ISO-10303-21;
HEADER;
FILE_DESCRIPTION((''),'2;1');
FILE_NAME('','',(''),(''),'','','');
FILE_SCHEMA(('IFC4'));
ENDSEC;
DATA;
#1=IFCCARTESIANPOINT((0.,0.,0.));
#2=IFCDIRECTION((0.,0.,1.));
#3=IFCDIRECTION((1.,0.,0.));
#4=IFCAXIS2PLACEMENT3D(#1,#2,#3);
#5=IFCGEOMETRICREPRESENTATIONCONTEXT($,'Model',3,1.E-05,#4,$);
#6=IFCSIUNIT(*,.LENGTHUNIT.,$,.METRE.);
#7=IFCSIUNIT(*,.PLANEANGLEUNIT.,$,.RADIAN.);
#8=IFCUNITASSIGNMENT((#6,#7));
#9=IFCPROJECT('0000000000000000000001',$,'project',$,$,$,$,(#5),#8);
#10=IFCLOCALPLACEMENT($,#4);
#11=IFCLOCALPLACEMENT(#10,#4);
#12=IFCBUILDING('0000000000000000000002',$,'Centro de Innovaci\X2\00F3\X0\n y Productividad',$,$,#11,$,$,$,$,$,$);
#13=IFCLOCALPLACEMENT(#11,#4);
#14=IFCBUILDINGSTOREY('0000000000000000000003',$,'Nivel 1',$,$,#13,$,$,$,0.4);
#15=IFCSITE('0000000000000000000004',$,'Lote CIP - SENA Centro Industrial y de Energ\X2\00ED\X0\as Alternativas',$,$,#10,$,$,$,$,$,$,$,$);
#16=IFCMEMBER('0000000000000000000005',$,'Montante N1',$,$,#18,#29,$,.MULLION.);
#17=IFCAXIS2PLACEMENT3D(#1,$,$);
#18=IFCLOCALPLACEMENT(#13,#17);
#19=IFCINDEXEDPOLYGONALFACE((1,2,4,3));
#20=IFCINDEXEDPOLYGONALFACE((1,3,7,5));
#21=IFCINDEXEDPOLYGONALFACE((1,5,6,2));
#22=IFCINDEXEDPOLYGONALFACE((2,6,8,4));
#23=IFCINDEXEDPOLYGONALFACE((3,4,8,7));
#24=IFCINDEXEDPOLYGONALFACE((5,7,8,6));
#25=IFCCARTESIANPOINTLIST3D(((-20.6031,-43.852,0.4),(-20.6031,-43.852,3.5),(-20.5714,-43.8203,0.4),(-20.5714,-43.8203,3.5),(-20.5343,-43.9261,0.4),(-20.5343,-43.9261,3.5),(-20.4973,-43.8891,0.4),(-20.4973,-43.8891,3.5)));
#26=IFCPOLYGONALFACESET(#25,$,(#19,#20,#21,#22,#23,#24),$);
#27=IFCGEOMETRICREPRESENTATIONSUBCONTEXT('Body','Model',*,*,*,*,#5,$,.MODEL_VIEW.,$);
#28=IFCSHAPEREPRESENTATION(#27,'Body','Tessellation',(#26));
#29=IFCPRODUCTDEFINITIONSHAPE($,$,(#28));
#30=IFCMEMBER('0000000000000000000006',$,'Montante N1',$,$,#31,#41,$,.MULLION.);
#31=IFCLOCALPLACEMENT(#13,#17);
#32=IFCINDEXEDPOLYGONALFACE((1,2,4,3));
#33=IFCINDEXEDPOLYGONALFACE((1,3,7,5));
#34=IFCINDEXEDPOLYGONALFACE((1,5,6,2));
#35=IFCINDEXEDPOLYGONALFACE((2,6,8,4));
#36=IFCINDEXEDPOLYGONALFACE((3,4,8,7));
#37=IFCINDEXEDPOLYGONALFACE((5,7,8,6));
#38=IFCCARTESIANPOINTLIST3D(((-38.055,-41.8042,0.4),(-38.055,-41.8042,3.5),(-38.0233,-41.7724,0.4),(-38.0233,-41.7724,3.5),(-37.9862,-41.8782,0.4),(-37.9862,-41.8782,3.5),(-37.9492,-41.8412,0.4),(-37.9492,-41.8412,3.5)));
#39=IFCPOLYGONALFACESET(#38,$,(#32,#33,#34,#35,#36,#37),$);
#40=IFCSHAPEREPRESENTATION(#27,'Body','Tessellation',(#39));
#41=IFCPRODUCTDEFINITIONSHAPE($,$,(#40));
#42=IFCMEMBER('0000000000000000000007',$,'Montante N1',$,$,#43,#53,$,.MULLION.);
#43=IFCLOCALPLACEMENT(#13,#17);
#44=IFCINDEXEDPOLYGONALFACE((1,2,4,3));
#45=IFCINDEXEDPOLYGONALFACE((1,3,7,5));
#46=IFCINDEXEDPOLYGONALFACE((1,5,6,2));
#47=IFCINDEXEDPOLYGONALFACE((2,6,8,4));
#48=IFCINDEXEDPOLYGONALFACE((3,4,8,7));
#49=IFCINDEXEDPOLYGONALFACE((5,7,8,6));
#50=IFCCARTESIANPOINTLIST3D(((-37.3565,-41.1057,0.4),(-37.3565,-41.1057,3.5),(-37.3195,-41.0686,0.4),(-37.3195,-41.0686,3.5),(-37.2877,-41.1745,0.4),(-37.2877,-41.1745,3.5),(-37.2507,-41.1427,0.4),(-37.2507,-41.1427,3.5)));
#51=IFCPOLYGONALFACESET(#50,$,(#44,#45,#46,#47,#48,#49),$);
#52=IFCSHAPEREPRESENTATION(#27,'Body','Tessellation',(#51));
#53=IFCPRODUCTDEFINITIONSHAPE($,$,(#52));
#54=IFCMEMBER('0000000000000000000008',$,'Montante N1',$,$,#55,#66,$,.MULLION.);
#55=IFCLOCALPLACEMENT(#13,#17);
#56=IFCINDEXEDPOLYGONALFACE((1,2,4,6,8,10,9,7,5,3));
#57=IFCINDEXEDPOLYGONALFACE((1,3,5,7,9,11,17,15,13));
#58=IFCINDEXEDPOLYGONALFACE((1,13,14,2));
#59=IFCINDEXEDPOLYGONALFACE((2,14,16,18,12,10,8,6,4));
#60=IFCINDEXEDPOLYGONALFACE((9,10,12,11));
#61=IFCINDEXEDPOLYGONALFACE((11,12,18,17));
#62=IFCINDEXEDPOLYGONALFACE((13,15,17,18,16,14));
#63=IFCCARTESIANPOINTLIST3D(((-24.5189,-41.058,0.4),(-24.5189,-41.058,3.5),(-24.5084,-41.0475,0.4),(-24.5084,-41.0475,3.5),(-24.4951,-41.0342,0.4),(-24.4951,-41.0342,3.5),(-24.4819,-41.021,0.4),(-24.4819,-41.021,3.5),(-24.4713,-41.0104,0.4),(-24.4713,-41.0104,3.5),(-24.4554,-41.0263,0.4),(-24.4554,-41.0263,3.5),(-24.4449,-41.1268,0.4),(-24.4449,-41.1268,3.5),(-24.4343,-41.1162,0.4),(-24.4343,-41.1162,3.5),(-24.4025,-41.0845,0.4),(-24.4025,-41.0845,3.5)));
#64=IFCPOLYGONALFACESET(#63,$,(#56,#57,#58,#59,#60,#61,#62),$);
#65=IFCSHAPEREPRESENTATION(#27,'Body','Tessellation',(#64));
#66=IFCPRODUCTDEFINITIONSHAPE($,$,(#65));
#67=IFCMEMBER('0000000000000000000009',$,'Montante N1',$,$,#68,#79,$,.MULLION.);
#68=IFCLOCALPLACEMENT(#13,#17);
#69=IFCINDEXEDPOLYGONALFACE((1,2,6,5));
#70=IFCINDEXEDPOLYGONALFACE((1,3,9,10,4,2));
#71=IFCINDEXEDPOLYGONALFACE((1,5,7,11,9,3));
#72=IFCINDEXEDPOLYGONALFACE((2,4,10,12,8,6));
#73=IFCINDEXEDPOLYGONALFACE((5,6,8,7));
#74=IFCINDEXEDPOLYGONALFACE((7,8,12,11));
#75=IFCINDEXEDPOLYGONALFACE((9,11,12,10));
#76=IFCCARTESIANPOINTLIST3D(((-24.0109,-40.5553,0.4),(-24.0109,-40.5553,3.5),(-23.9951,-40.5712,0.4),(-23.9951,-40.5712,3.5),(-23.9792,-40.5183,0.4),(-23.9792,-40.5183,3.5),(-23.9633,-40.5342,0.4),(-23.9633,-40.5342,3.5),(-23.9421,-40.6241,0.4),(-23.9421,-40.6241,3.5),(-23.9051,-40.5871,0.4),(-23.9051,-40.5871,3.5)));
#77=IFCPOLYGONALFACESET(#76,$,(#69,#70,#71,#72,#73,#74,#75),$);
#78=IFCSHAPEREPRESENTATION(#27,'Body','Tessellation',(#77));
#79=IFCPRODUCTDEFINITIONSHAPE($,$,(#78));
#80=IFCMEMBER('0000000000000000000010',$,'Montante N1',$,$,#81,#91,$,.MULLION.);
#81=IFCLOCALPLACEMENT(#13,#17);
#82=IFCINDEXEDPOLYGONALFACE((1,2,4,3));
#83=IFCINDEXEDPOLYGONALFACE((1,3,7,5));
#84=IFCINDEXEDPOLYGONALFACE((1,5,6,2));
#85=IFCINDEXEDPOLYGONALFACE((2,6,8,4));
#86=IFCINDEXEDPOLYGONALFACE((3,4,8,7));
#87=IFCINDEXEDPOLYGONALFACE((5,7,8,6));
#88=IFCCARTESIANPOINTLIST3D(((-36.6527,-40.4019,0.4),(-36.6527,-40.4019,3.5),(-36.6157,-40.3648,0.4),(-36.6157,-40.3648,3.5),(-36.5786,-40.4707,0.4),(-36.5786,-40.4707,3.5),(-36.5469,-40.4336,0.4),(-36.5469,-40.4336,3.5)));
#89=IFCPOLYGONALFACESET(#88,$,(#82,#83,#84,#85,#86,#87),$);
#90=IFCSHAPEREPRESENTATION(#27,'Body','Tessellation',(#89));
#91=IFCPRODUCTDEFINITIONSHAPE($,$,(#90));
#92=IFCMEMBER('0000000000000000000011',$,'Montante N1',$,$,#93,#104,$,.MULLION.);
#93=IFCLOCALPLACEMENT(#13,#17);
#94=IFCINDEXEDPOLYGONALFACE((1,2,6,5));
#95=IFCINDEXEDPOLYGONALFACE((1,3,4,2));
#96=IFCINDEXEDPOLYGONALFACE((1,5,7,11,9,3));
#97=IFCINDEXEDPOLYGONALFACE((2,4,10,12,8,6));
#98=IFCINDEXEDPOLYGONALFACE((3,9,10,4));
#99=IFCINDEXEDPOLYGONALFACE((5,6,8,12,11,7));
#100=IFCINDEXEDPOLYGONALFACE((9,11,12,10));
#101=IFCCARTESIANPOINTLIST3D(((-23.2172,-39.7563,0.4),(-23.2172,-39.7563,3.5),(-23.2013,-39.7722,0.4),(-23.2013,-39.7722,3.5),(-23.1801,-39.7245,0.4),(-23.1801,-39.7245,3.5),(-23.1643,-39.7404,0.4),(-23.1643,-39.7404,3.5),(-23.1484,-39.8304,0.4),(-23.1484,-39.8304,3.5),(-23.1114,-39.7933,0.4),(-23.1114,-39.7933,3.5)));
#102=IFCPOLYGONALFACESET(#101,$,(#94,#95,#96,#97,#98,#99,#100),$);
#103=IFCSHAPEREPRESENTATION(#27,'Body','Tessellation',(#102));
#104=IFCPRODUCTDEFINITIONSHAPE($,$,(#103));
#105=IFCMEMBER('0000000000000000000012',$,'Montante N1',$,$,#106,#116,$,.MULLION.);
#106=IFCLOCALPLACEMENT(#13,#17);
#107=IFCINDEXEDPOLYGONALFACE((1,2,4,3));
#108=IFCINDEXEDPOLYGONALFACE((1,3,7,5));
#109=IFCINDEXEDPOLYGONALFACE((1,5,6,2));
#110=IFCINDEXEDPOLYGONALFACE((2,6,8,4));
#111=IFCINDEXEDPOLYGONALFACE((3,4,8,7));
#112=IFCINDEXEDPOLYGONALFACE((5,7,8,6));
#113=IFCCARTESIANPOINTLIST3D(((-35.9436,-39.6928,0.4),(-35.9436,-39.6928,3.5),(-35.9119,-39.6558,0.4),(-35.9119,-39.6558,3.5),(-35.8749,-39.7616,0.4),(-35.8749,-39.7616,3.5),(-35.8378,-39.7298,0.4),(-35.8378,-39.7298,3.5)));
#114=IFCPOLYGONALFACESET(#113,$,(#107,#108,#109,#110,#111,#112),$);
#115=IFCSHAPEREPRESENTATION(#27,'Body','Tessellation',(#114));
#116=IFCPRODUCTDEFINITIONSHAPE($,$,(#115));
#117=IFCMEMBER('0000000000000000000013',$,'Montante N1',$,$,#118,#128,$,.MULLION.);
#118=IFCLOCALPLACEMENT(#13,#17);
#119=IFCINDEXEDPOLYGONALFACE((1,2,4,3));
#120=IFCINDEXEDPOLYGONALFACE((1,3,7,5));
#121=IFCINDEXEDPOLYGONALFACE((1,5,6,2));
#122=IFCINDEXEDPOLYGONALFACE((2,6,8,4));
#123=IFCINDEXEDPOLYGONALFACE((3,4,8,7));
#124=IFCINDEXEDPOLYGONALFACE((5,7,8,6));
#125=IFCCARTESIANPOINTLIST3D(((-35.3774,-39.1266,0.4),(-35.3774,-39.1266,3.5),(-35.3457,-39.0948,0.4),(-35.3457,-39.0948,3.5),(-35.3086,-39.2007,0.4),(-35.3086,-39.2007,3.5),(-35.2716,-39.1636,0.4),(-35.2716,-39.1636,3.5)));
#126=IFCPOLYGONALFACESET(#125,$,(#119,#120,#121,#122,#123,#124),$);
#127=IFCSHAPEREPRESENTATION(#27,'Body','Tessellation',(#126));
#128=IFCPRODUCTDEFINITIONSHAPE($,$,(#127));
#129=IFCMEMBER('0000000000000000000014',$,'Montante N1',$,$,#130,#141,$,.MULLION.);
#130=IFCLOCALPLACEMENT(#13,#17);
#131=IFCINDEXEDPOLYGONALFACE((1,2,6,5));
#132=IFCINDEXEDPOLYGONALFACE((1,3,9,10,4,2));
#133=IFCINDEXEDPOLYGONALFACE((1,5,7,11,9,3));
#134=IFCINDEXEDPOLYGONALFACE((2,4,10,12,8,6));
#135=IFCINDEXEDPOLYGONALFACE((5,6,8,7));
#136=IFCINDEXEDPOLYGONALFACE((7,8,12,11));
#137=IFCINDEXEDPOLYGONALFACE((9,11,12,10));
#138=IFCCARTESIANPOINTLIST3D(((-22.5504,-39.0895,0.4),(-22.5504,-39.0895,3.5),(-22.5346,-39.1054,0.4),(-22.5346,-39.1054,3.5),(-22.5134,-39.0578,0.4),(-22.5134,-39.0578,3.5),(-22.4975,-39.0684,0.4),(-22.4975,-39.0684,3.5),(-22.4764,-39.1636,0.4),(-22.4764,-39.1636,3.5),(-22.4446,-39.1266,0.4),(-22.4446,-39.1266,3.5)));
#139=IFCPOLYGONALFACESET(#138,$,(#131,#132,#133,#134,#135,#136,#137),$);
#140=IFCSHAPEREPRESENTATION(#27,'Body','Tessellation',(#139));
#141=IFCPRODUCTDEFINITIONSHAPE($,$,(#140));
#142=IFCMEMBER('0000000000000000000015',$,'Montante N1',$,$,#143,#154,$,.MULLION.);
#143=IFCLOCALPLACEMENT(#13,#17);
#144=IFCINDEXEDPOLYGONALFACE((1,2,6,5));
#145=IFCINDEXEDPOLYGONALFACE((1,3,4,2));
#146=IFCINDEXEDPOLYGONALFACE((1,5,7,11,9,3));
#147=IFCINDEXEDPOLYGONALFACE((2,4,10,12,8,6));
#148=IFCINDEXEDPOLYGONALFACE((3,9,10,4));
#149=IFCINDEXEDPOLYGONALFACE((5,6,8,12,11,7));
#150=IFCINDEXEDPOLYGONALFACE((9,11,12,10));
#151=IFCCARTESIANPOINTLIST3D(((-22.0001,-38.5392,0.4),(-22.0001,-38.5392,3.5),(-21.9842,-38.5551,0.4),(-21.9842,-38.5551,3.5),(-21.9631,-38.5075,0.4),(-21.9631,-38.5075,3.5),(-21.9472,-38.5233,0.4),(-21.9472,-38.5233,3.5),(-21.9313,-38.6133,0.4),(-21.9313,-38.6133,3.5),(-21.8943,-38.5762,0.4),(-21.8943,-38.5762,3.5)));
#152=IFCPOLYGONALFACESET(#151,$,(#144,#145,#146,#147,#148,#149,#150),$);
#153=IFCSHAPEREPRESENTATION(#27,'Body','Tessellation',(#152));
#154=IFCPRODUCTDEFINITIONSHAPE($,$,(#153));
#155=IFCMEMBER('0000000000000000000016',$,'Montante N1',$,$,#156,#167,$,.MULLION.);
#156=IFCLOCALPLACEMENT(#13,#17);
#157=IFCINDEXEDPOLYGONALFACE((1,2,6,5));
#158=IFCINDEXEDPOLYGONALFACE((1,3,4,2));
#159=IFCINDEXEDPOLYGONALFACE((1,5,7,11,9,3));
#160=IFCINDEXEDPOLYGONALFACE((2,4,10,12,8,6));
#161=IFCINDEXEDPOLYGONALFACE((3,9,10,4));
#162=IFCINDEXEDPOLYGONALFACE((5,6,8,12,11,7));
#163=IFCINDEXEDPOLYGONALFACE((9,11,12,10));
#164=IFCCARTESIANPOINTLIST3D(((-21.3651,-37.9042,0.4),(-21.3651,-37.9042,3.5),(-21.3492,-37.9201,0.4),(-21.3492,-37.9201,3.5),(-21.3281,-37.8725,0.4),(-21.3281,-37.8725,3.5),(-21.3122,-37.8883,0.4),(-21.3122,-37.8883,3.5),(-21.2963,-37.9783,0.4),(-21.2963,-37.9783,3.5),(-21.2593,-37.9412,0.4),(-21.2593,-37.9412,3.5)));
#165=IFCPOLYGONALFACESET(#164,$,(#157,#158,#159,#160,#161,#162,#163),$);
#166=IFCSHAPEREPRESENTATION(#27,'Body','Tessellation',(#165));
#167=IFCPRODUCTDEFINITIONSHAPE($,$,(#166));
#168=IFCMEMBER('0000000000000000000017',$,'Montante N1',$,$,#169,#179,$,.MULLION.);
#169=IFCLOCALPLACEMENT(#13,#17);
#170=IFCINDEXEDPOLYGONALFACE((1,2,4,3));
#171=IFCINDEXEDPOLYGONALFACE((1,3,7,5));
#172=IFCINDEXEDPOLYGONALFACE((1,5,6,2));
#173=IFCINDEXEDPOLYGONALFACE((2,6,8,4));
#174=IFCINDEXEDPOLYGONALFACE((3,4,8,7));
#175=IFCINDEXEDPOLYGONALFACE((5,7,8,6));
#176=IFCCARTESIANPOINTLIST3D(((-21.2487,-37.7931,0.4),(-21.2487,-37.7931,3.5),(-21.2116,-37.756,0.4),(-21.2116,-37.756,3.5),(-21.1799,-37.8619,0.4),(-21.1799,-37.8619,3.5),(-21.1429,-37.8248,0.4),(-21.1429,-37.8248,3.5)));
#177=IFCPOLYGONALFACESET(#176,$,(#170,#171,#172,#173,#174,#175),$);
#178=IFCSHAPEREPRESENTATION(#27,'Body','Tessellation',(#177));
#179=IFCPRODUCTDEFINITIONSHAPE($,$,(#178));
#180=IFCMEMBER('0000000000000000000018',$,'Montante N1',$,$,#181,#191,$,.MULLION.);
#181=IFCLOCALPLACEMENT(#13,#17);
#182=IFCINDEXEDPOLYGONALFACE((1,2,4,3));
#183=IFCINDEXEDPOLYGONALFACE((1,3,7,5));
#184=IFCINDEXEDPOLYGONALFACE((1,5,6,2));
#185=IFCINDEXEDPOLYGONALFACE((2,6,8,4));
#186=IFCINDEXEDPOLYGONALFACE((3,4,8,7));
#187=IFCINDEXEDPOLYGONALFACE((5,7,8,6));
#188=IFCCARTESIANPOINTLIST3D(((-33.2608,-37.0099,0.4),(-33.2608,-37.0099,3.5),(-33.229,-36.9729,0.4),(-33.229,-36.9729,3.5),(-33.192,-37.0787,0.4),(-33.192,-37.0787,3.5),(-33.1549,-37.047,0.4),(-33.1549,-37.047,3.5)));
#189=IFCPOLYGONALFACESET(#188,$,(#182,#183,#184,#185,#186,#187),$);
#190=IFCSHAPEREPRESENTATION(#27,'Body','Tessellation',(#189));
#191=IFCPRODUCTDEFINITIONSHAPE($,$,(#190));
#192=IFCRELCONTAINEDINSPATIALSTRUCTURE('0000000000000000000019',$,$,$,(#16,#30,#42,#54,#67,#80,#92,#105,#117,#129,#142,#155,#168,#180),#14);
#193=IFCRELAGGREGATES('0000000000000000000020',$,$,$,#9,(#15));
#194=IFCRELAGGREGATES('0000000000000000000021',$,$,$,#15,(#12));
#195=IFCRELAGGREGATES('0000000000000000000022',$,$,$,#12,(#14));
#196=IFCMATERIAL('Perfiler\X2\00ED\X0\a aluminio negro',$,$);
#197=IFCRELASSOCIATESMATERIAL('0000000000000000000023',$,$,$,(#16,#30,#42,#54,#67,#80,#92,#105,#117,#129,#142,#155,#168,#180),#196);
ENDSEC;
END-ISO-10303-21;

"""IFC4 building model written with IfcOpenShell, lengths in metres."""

from ifc_helpers import new_model, si_unit, frame, origin_with_axes, place, context, subcontext, project, spatial, polyline, outline, extrude, material, element, save


model = new_model("IFC4")

# Units and contexts
model_context = context("Model", 3, precision=1e-05, world=origin_with_axes())
body_context = subcontext(model_context, "Body", "Model", "MODEL_VIEW")
ifc_project = project(units=[si_unit("LENGTHUNIT", "METRE"), si_unit("PLANEANGLEUNIT", "RADIAN")], contexts=[model_context])

# Site, building, storey
site_placement = place(None, origin_with_axes())
site = spatial("IfcSite", under=ifc_project, at=site_placement, Name="Lote CIP - SENA Centro Industrial y de Energías Alternativas")
building_placement = place(site_placement, origin_with_axes())
building = spatial("IfcBuilding", under=site, at=building_placement, Name="Centro de Innovación y Productividad")
storey_placement = place(building_placement, origin_with_axes())
storey = spatial("IfcBuildingStorey", under=building, at=storey_placement, Name="Nivel 1", Elevation=0.4)

# Members
ifc_material = material(Name="Perfilería aluminio negro")
member_1_placement = place(storey_placement, origin_with_axes())
element("IfcMember", 1, at=member_1_placement, inside=storey, material=ifc_material, Name="Montante N1", PredefinedType="MULLION", context=body_context, shape_type="SweptSolid", body=[
    extrude(outline(polyline([(-20.5714, -43.8203), (-20.4973, -43.8891), (-20.5343, -43.9261), (-20.6031, -43.852), (-20.5714, -43.8203)])), frame((0.0, 0.0, 0.4)), (0.0, 0.0, 1.0), 3.1),
])
member_2_placement = place(storey_placement, origin_with_axes())
element("IfcMember", 2, at=member_2_placement, inside=storey, material=ifc_material, Name="Montante N1", PredefinedType="MULLION", context=body_context, shape_type="SweptSolid", body=[
    extrude(outline(polyline([(-37.9862, -41.8783), (-38.055, -41.8042), (-38.0233, -41.7724), (-37.9492, -41.8412), (-37.9862, -41.8783)])), frame((0.0, 0.0, 0.4)), (0.0, 0.0, 1.0), 3.1),
])
member_3_placement = place(storey_placement, origin_with_axes())
element("IfcMember", 3, at=member_3_placement, inside=storey, material=ifc_material, Name="Montante N1", PredefinedType="MULLION", context=body_context, shape_type="SweptSolid", body=[
    extrude(outline(polyline([(-37.2877, -41.1745), (-37.3565, -41.1057), (-37.3195, -41.0686), (-37.2507, -41.1427), (-37.2877, -41.1745)])), frame((0.0, 0.0, 0.4)), (0.0, 0.0, 1.0), 3.1),
])
member_4_placement = place(storey_placement, origin_with_axes())
element("IfcMember", 4, at=member_4_placement, inside=storey, material=ifc_material, Name="Montante N1", PredefinedType="MULLION", context=body_context, shape_type="SweptSolid", body=[
    extrude(outline(polyline([(-24.4343, -41.1162), (-24.4343, -41.1162), (-24.4449, -41.1268), (-24.5189, -41.058), (-24.5084, -41.0475), (-24.4951, -41.0342), (-24.4819, -41.021), (-24.4713, -41.0104), (-24.4554, -41.0263), (-24.4025, -41.0845), (-24.4343, -41.1162)])), frame((0.0, 0.0, 0.4)), (0.0, 0.0, 1.0), 3.1),
])
member_5_placement = place(storey_placement, origin_with_axes())
element("IfcMember", 5, at=member_5_placement, inside=storey, material=ifc_material, Name="Montante N1", PredefinedType="MULLION", context=body_context, shape_type="SweptSolid", body=[
    extrude(outline(polyline([(-23.9421, -40.6241), (-23.9951, -40.5712), (-24.0109, -40.5553), (-23.9792, -40.5183), (-23.9633, -40.5342), (-23.9051, -40.5871), (-23.9421, -40.6241)])), frame((0.0, 0.0, 0.4)), (0.0, 0.0, 1.0), 3.1),
])
member_6_placement = place(storey_placement, origin_with_axes())
element("IfcMember", 6, at=member_6_placement, inside=storey, material=ifc_material, Name="Montante N1", PredefinedType="MULLION", context=body_context, shape_type="SweptSolid", body=[
    extrude(outline(polyline([(-36.6527, -40.4019), (-36.6157, -40.3648), (-36.5469, -40.4336), (-36.5786, -40.4707), (-36.6527, -40.4019)])), frame((0.0, 0.0, 0.4)), (0.0, 0.0, 1.0), 3.1),
])
member_7_placement = place(storey_placement, origin_with_axes())
element("IfcMember", 7, at=member_7_placement, inside=storey, material=ifc_material, Name="Montante N1", PredefinedType="MULLION", context=body_context, shape_type="SweptSolid", body=[
    extrude(outline(polyline([(-23.1643, -39.7404), (-23.1114, -39.7933), (-23.1484, -39.8304), (-23.2013, -39.7722), (-23.2172, -39.7563), (-23.1801, -39.7245), (-23.1643, -39.7404)])), frame((0.0, 0.0, 0.4)), (0.0, 0.0, 1.0), 3.1),
])
member_8_placement = place(storey_placement, origin_with_axes())
element("IfcMember", 8, at=member_8_placement, inside=storey, material=ifc_material, Name="Montante N1", PredefinedType="MULLION", context=body_context, shape_type="SweptSolid", body=[
    extrude(outline(polyline([(-35.8749, -39.7616), (-35.9436, -39.6928), (-35.9119, -39.6557), (-35.8378, -39.7298), (-35.8749, -39.7616)])), frame((0.0, 0.0, 0.4)), (0.0, 0.0, 1.0), 3.1),
])
member_9_placement = place(storey_placement, origin_with_axes())
element("IfcMember", 9, at=member_9_placement, inside=storey, material=ifc_material, Name="Montante N1", PredefinedType="MULLION", context=body_context, shape_type="SweptSolid", body=[
    extrude(outline(polyline([(-35.2716, -39.1636), (-35.3086, -39.2007), (-35.3774, -39.1266), (-35.3457, -39.0948), (-35.2716, -39.1636)])), frame((0.0, 0.0, 0.4)), (0.0, 0.0, 1.0), 3.1),
])
member_10_placement = place(storey_placement, origin_with_axes())
element("IfcMember", 10, at=member_10_placement, inside=storey, material=ifc_material, Name="Montante N1", PredefinedType="MULLION", context=body_context, shape_type="SweptSolid", body=[
    extrude(outline(polyline([(-22.4764, -39.1636), (-22.5346, -39.1054), (-22.5504, -39.0895), (-22.5134, -39.0578), (-22.4975, -39.0684), (-22.4446, -39.1266), (-22.4764, -39.1636)])), frame((0.0, 0.0, 0.4)), (0.0, 0.0, 1.0), 3.1),
])
member_11_placement = place(storey_placement, origin_with_axes())
element("IfcMember", 11, at=member_11_placement, inside=storey, material=ifc_material, Name="Montante N1", PredefinedType="MULLION", context=body_context, shape_type="SweptSolid", body=[
    extrude(outline(polyline([(-22.0001, -38.5392), (-21.9631, -38.5075), (-21.9472, -38.5233), (-21.8943, -38.5762), (-21.9313, -38.6133), (-21.9842, -38.5551), (-22.0001, -38.5392)])), frame((0.0, 0.0, 0.4)), (0.0, 0.0, 1.0), 3.1),
])
member_12_placement = place(storey_placement, origin_with_axes())
element("IfcMember", 12, at=member_12_placement, inside=storey, material=ifc_material, Name="Montante N1", PredefinedType="MULLION", context=body_context, shape_type="SweptSolid", body=[
    extrude(outline(polyline([(-21.3122, -37.8883), (-21.2593, -37.9412), (-21.2963, -37.9783), (-21.3492, -37.9201), (-21.3651, -37.9042), (-21.3281, -37.8725), (-21.3122, -37.8883)])), frame((0.0, 0.0, 0.4)), (0.0, 0.0, 1.0), 3.1),
])
member_13_placement = place(storey_placement, origin_with_axes())
element("IfcMember", 13, at=member_13_placement, inside=storey, material=ifc_material, Name="Montante N1", PredefinedType="MULLION", context=body_context, shape_type="SweptSolid", body=[
    extrude(outline(polyline([(-21.2487, -37.7931), (-21.2116, -37.756), (-21.1429, -37.8248), (-21.1799, -37.8619), (-21.2487, -37.7931)])), frame((0.0, 0.0, 0.4)), (0.0, 0.0, 1.0), 3.1),
])
member_14_placement = place(storey_placement, origin_with_axes())
element("IfcMember", 14, at=member_14_placement, inside=storey, material=ifc_material, Name="Montante N1", PredefinedType="MULLION", context=body_context, shape_type="SweptSolid", body=[
    extrude(outline(polyline([(-33.2608, -37.0099), (-33.229, -36.9729), (-33.1549, -37.047), (-33.192, -37.0787), (-33.2608, -37.0099)])), frame((0.0, 0.0, 0.4)), (0.0, 0.0, 1.0), 3.1),
])

save(model, "model.ifc")
